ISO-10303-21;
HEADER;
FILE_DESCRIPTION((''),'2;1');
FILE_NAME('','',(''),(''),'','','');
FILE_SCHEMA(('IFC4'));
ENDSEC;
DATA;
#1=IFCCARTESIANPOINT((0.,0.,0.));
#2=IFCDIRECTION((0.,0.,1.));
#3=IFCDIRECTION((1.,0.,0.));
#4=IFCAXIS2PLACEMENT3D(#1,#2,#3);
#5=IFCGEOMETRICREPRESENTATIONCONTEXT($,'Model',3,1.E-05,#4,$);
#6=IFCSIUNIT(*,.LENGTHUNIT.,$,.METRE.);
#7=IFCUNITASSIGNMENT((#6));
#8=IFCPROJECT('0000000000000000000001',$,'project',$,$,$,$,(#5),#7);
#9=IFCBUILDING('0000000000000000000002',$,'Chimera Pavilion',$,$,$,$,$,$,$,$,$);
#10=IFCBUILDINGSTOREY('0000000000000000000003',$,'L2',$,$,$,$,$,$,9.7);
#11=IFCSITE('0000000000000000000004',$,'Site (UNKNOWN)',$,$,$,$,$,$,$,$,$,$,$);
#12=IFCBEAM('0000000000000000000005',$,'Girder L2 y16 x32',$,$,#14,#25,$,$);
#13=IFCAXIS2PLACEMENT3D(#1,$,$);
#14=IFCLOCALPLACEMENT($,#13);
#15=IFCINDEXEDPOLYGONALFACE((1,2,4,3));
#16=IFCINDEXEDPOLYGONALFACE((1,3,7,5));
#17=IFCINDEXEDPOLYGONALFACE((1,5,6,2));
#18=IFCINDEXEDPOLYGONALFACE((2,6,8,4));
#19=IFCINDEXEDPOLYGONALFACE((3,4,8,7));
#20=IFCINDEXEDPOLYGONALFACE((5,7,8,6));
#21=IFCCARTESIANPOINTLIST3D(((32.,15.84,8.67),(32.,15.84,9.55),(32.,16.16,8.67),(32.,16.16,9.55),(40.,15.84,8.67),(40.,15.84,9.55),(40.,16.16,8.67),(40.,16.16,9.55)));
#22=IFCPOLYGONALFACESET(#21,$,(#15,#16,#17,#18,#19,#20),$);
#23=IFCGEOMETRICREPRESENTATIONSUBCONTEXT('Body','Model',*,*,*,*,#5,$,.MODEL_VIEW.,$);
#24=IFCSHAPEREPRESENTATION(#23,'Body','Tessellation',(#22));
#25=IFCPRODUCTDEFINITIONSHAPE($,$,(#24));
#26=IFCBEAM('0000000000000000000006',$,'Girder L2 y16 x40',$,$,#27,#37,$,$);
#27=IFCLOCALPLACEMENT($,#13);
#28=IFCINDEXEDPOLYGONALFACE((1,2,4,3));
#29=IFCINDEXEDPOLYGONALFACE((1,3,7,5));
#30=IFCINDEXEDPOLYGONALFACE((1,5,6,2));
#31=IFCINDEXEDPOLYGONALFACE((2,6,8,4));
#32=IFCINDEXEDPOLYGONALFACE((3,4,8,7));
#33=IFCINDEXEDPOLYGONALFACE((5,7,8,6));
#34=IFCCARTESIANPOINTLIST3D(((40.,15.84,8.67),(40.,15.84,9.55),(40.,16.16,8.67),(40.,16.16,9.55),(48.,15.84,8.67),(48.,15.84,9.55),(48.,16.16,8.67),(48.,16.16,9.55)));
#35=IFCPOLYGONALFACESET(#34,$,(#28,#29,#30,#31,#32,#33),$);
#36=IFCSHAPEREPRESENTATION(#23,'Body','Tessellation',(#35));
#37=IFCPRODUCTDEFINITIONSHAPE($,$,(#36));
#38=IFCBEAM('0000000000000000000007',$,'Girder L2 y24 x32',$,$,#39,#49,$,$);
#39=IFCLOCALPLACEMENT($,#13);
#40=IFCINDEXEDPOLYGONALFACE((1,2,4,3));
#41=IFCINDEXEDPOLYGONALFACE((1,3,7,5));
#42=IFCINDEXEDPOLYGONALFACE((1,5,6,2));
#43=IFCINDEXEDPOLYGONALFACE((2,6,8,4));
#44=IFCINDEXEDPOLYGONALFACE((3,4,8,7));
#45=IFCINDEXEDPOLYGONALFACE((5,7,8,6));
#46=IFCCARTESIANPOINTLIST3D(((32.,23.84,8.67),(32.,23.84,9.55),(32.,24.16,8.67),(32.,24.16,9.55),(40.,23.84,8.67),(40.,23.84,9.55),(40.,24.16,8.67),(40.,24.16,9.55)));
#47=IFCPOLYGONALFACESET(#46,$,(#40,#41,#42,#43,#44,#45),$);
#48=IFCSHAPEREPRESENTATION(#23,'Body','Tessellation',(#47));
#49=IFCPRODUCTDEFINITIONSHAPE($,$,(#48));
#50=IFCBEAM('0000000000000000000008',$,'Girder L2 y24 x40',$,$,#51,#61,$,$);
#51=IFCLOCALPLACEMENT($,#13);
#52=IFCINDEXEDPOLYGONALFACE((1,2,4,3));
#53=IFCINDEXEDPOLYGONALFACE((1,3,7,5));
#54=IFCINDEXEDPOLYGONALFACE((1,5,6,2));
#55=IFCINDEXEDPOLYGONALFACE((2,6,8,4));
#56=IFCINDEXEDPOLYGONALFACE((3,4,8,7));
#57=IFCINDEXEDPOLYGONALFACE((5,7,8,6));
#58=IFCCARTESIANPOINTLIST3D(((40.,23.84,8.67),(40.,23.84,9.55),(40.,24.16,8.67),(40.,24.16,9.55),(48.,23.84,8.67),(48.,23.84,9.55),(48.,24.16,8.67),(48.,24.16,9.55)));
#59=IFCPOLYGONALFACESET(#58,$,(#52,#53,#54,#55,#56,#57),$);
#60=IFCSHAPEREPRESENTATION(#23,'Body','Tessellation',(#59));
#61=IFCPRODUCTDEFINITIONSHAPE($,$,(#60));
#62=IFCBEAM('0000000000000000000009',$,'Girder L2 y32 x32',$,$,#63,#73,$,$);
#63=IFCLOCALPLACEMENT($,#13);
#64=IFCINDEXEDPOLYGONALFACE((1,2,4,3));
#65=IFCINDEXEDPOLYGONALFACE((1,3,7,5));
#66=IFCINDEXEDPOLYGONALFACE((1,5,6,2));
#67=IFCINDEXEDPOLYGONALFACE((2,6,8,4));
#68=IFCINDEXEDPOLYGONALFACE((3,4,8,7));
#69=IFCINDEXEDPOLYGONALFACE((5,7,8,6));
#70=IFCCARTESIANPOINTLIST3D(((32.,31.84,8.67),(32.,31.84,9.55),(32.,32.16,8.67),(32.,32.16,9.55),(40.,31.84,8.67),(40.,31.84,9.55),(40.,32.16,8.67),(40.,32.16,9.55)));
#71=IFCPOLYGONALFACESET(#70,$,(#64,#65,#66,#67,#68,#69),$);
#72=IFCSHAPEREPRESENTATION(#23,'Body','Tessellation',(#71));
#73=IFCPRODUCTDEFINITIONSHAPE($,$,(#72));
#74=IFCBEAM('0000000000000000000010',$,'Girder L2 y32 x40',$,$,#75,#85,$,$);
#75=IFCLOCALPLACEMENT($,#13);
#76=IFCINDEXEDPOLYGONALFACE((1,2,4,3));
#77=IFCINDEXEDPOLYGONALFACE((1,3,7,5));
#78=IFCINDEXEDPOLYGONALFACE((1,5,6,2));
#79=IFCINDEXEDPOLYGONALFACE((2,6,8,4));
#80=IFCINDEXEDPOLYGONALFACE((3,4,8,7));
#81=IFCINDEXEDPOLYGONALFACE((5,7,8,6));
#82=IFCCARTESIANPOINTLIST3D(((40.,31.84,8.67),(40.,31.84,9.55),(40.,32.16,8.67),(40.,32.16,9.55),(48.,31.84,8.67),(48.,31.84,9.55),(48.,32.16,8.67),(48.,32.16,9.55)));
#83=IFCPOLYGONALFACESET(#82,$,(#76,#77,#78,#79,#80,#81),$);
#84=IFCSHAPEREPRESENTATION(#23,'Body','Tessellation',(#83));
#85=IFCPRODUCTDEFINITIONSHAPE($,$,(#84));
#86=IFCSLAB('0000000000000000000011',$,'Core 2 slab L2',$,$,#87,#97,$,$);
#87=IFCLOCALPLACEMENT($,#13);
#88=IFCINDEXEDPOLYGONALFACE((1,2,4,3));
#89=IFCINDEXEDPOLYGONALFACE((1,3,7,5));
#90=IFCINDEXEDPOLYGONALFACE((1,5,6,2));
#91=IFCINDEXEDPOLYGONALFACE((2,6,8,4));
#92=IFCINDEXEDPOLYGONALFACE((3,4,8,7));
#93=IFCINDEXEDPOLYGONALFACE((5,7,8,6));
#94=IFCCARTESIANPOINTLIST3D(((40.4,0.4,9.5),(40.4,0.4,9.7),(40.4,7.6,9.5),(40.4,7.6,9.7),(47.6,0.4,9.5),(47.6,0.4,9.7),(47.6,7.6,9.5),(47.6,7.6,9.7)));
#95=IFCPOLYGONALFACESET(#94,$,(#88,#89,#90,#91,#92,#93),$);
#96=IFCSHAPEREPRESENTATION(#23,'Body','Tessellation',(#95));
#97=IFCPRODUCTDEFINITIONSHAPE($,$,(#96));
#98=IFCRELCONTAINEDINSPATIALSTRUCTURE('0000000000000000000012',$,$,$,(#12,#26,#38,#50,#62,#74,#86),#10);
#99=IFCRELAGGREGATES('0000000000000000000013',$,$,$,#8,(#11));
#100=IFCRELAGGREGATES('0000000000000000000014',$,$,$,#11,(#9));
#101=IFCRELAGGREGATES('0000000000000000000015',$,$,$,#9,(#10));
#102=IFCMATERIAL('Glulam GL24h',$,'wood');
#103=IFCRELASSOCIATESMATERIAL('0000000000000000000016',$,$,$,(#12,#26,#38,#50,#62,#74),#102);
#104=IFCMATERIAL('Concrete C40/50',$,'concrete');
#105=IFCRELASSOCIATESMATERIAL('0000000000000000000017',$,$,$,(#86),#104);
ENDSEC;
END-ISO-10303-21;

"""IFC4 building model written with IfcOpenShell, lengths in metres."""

from ifc_helpers import new_model, si_unit, frame, origin_with_axes, place, context, subcontext, project, spatial, rectangle, extrude, material, element, save


model = new_model("IFC4")

# Units and contexts
model_context = context("Model", 3, precision=1e-05, world=origin_with_axes())
body_context = subcontext(model_context, "Body", "Model", "MODEL_VIEW")
ifc_project = project(units=[si_unit("LENGTHUNIT", "METRE")], contexts=[model_context])

# Site, building, storey
site = spatial("IfcSite", under=ifc_project, Name="Site (UNKNOWN)")
building = spatial("IfcBuilding", under=site, Name="Chimera Pavilion")
storey = spatial("IfcBuildingStorey", under=building, Name="L2", Elevation=9.7)

# Beams
ifc_material_1 = material(Name="Glulam GL24h", Category="wood")
for number, where, z_axis, x_axis, name in (
    (1, (32.0, 16.0, 9.11), (1.0, 0.0, 0.0), (0.0, -1.0, 0.0), "Girder L2 y16 x32"),
    (2, (40.0, 16.0, 9.11), (1.0, 0.0, 0.0), (0.0, -1.0, 0.0), "Girder L2 y16 x40"),
    (3, (32.0, 24.0, 9.11), (1.0, 0.0, 0.0), (0.0, -1.0, 0.0), "Girder L2 y24 x32"),
    (4, (40.0, 24.0, 9.11), (1.0, 0.0, 0.0), (0.0, -1.0, 0.0), "Girder L2 y24 x40"),
    (5, (32.0, 32.0, 9.11), (1.0, 0.0, 0.0), (0.0, -1.0, 0.0), "Girder L2 y32 x32"),
    (6, (40.0, 32.0, 9.11), (1.0, 0.0, 0.0), (0.0, -1.0, 0.0), "Girder L2 y32 x40"),
):
    element("IfcBeam", number, at=place(None, frame(where, z_axis=z_axis, x_axis=x_axis)), inside=storey, material=ifc_material_1, Name=name, context=body_context, shape_type="SweptSolid", body=[
        extrude(rectangle(XDim=0.32, YDim=0.88), origin_with_axes(), (0.0, 0.0, 1.0), 8.0),
    ])

# Slab
ifc_material_2 = material(Name="Concrete C40/50", Category="concrete")
slab_placement = place(None, frame((44.0, 4.0, 9.5), z_axis=(0.0, 0.0, 1.0), x_axis=(1.0, 0.0, 0.0)))
element("IfcSlab", 7, at=slab_placement, inside=storey, material=ifc_material_2, Name="Core 2 slab L2", context=body_context, shape_type="SweptSolid", body=[
    extrude(rectangle(XDim=7.2, YDim=7.2), origin_with_axes(), (0.0, 0.0, 1.0), 0.2),
])

save(model, "model.ifc")
